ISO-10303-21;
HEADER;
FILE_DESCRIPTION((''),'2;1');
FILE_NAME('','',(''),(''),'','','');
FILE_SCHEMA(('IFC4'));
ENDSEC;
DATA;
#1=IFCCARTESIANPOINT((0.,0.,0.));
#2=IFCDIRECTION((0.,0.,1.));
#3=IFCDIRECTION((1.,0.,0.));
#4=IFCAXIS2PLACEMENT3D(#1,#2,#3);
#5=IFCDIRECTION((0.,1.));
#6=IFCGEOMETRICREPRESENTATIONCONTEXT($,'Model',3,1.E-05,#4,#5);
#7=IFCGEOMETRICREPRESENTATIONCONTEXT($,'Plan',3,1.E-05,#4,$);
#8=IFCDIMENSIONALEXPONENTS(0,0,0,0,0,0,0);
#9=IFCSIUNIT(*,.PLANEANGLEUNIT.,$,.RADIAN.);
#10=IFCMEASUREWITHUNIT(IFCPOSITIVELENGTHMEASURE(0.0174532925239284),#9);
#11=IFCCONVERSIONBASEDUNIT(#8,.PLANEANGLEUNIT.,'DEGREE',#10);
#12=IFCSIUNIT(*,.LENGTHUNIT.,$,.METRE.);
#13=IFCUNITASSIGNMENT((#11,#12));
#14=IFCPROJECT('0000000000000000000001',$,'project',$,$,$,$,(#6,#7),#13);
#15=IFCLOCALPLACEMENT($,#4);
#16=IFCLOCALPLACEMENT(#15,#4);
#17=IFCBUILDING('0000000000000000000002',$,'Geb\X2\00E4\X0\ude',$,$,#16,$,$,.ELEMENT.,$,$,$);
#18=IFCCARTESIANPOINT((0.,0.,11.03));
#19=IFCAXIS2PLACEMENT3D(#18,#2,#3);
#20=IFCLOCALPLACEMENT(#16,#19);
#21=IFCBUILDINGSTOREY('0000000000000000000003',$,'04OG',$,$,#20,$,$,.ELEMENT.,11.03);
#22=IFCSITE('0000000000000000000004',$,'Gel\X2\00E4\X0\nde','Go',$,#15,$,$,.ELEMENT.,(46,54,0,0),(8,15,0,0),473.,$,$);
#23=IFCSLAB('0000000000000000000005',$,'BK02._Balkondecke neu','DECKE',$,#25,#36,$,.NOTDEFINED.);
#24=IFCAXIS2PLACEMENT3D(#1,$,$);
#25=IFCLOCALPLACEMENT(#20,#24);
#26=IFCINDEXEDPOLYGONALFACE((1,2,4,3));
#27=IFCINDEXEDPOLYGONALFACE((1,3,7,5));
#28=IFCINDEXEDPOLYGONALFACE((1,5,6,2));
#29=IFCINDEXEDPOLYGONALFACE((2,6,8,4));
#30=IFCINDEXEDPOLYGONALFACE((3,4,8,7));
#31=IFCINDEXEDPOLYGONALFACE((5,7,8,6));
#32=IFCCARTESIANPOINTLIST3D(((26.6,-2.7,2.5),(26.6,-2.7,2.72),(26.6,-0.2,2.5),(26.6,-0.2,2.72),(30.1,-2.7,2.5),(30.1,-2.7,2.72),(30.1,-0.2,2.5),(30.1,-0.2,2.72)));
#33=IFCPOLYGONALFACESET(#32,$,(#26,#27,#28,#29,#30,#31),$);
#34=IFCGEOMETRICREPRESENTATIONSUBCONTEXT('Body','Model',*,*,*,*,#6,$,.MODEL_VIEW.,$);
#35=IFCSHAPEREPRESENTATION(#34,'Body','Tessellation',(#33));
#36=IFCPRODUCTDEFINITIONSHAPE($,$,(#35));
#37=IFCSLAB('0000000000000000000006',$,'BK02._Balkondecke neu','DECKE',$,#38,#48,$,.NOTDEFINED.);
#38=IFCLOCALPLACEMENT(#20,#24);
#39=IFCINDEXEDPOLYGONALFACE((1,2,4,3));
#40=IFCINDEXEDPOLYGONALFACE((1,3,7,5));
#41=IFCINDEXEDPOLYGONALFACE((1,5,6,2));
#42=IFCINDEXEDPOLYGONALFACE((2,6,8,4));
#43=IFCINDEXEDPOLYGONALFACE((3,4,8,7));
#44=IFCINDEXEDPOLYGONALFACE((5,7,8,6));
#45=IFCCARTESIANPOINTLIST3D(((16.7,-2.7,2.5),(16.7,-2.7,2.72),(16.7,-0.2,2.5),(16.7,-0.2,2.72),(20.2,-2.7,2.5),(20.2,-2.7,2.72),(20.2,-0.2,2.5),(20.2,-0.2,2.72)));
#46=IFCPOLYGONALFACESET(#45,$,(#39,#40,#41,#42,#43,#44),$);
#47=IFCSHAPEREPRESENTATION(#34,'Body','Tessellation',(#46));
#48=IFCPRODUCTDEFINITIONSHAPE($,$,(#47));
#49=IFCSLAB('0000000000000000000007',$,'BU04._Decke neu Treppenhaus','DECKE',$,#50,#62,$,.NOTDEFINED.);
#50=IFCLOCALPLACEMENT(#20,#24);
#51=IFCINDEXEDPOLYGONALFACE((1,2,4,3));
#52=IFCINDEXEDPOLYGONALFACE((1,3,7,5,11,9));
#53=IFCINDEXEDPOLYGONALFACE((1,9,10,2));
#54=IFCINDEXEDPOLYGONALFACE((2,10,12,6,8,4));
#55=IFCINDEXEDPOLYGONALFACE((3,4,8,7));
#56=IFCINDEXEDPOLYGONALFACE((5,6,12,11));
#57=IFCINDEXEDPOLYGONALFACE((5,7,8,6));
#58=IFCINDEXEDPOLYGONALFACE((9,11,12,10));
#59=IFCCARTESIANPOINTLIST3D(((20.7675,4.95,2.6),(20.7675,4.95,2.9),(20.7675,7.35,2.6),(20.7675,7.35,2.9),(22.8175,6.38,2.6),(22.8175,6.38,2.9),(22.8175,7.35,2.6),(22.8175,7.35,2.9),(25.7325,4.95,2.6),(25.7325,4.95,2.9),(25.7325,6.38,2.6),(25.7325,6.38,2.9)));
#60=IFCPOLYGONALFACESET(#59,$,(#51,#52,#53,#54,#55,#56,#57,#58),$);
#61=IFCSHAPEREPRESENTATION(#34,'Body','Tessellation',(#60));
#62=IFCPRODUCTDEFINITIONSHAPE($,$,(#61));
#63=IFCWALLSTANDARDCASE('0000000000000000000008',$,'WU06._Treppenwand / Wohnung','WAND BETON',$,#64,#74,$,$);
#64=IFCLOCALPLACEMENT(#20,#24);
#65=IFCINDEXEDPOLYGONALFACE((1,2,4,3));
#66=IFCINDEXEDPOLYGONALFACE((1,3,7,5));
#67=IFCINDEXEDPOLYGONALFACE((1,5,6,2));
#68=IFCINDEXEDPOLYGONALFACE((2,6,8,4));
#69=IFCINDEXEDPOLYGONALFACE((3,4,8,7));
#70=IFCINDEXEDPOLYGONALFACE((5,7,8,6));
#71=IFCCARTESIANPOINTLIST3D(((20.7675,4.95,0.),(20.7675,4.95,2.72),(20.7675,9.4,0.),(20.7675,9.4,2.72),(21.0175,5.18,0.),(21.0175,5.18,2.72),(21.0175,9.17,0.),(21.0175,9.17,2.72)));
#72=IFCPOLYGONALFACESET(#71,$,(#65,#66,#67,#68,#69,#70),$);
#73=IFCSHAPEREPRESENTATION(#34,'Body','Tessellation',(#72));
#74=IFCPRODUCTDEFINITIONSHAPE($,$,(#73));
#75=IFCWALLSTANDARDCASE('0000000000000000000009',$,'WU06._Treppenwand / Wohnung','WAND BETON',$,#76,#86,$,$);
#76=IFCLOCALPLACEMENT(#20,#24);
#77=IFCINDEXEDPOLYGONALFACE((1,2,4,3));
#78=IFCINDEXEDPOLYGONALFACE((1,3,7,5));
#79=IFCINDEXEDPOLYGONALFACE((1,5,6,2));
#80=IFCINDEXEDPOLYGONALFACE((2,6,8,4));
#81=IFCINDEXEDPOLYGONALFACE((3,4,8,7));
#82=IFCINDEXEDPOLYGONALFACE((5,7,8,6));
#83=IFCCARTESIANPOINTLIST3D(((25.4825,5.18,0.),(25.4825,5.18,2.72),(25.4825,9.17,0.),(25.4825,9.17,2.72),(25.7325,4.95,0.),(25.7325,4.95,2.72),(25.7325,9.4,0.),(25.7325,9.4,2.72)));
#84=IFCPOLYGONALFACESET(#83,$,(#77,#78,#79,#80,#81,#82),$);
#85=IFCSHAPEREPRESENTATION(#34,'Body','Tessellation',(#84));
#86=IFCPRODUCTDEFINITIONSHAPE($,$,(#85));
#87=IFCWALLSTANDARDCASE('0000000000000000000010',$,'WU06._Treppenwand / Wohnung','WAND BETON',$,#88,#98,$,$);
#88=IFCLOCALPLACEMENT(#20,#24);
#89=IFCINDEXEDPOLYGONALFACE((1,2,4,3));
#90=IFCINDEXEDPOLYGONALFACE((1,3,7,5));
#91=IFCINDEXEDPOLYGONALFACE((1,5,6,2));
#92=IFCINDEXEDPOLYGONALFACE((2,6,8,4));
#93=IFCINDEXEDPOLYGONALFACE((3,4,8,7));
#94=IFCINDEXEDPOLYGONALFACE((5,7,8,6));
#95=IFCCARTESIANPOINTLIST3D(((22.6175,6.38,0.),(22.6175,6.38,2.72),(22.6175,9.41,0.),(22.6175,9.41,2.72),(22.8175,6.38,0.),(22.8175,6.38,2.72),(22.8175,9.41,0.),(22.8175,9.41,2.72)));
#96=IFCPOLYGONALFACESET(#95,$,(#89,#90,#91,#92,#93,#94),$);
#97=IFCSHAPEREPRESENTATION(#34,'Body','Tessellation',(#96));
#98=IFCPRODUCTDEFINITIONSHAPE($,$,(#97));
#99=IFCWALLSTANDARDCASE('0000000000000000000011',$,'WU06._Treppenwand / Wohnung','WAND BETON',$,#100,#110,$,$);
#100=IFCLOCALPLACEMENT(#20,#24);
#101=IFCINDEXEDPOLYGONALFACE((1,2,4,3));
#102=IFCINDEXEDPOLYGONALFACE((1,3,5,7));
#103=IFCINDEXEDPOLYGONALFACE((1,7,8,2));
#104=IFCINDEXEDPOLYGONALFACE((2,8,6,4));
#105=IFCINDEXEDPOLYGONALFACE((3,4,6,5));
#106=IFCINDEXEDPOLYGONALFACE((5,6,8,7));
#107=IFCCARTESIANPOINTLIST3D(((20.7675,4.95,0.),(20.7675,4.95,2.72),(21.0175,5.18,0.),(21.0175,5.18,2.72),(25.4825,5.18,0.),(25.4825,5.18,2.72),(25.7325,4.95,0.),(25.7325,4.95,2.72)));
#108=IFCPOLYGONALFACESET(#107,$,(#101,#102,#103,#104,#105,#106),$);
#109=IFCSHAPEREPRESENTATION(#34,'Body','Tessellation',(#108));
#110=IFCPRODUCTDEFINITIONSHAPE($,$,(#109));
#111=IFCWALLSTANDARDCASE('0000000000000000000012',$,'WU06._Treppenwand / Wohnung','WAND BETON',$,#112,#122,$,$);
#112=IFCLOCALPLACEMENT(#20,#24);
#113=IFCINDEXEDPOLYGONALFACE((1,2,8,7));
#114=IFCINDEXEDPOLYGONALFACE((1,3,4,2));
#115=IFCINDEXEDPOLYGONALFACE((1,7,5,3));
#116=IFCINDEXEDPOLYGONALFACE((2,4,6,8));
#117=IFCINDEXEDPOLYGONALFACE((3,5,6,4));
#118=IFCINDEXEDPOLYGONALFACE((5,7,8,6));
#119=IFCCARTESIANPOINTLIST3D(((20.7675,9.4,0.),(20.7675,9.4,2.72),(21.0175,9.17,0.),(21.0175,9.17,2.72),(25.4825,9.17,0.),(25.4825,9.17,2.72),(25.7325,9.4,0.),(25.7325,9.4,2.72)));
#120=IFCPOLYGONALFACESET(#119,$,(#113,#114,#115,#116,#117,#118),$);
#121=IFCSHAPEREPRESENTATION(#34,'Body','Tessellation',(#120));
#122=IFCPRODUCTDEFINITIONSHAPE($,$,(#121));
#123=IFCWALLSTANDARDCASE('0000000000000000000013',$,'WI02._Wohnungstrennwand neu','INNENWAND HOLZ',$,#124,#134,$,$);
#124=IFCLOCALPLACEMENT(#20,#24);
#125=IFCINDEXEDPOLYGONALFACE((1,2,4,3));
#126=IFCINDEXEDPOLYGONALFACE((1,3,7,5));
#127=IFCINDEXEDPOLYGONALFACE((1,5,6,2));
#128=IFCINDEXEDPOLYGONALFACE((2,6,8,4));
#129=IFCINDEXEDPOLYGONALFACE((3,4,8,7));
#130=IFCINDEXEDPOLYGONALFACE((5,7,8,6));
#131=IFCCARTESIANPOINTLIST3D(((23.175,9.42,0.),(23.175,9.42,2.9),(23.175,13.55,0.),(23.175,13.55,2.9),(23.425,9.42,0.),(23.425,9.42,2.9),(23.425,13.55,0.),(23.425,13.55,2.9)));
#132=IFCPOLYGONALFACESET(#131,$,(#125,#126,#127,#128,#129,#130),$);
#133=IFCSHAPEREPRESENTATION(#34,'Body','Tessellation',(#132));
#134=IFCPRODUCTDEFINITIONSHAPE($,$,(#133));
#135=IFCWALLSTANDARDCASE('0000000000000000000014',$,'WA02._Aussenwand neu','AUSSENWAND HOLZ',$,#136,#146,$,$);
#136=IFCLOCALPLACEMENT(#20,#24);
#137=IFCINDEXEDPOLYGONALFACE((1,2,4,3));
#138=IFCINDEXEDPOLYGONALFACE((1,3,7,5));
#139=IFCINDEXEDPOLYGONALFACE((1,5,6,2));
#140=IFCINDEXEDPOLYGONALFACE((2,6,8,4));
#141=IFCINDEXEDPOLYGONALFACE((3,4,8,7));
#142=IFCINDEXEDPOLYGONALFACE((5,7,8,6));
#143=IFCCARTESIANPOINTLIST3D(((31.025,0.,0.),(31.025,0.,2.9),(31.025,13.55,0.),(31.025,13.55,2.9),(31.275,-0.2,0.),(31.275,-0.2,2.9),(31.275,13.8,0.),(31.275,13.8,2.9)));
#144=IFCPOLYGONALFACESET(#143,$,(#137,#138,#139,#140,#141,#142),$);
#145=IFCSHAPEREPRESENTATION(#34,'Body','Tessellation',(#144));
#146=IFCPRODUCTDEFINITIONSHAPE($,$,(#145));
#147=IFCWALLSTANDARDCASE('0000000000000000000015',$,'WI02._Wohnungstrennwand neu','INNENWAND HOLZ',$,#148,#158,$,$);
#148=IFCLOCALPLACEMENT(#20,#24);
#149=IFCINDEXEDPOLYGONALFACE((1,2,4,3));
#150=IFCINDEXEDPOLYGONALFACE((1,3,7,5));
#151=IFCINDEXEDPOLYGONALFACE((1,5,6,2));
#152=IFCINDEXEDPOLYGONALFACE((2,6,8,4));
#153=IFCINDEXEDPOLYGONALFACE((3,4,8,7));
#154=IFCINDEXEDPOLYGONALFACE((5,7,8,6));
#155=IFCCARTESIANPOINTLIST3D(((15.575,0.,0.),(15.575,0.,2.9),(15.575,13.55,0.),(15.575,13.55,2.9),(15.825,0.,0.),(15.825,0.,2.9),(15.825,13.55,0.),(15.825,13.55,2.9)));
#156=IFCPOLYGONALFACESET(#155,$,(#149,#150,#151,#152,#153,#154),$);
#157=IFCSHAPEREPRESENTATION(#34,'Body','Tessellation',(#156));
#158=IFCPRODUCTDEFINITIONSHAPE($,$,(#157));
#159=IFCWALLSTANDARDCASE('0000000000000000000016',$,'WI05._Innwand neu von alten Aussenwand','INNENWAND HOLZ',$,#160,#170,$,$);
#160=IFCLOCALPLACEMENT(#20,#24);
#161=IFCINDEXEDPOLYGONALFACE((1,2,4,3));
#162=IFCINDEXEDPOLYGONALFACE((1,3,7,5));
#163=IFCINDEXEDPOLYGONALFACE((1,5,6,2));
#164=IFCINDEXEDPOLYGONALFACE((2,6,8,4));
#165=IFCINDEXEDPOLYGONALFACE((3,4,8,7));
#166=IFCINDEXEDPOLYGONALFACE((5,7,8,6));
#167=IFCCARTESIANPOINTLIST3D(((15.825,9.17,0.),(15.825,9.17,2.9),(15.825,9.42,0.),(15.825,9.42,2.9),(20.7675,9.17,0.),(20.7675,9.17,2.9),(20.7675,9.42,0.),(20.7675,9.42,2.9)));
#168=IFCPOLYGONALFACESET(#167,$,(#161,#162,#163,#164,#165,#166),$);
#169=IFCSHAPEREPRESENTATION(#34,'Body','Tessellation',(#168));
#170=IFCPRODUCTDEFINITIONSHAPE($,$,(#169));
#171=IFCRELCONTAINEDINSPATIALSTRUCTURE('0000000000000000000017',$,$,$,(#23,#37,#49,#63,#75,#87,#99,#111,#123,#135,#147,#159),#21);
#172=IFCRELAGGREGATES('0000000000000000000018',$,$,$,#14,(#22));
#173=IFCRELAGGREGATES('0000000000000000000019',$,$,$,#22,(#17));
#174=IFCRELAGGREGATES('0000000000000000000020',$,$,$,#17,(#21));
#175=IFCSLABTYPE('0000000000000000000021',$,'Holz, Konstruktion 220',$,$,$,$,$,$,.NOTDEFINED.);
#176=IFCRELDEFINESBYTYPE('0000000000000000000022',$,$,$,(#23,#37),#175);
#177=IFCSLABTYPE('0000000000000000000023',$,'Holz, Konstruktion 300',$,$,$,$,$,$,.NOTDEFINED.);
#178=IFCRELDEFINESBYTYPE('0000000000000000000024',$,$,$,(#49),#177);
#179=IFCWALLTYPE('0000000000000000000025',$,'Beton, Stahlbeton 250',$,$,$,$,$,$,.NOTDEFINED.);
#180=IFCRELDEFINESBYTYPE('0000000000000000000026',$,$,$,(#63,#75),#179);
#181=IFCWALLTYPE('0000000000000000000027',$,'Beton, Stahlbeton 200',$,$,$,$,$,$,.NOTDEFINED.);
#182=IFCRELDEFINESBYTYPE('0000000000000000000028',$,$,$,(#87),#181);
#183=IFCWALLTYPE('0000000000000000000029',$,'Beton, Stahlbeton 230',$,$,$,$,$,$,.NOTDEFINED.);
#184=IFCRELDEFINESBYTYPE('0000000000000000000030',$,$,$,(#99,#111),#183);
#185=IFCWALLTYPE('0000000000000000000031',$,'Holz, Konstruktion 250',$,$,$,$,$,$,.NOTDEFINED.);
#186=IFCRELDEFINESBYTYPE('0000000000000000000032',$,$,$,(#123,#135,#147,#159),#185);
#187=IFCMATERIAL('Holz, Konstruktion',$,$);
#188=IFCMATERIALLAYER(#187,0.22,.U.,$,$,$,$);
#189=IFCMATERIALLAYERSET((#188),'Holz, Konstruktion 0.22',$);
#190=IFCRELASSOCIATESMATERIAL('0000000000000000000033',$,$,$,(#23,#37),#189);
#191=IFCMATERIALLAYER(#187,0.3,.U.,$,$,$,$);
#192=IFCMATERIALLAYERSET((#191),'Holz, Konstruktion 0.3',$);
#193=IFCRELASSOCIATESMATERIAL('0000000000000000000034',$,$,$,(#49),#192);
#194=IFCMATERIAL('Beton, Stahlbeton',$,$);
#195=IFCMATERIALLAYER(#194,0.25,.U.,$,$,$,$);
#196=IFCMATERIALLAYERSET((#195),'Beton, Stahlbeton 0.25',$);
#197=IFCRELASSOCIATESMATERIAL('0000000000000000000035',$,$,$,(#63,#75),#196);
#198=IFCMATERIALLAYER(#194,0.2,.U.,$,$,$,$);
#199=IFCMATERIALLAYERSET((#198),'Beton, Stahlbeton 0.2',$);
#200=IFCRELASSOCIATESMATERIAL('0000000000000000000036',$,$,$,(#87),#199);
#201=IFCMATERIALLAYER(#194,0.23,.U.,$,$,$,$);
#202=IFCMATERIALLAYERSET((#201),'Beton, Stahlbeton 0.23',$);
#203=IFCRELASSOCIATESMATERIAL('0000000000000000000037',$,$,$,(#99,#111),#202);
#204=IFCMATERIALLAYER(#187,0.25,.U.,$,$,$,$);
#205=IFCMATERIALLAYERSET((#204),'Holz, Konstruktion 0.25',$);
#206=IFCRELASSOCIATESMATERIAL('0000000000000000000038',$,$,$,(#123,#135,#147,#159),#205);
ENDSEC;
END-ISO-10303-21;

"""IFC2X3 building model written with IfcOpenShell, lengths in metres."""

from ifc_helpers import new_model, entity, si_unit, converted_unit, direction, frame, origin_with_axes, place, context, subcontext, project, spatial, polyline, outline, extrude, material, layer, layer_set, layer_usage, type_object, element, save


model = new_model("IFC2X3")

# Units and contexts
model_context = context("Model", 3, precision=1e-05, world=origin_with_axes(), true_north=direction((0.0, 1.0)))
plan_context = context("Plan", 3, precision=1e-05, world=origin_with_axes())
body_context = subcontext(model_context, "Body", "Model", "MODEL_VIEW")
ifc_project = project(units=[converted_unit("PLANEANGLEUNIT", "DEGREE", entity("IfcPositiveLengthMeasure", 0.0174532925239284), si_unit("PLANEANGLEUNIT", "RADIAN"), dimensions=[0, 0, 0, 0, 0, 0, 0]), si_unit("LENGTHUNIT", "METRE")], contexts=[model_context, plan_context])

# Site, building, storey
site_placement = place(None, origin_with_axes())
site = spatial("IfcSite", under=ifc_project, at=site_placement, Name="Gelände", Description="Go", CompositionType="ELEMENT", RefLatitude=(46, 54, 0, 0), RefLongitude=(8, 15, 0, 0), RefElevation=473.0)
building_placement = place(site_placement, origin_with_axes())
building = spatial("IfcBuilding", under=site, at=building_placement, Name="Gebäude", CompositionType="ELEMENT")
storey_placement = place(building_placement, frame((0.0, 0.0, 11.03), z_axis=(0.0, 0.0, 1.0), x_axis=(1.0, 0.0, 0.0)))
storey = spatial("IfcBuildingStorey", under=building, at=storey_placement, Name="04OG", CompositionType="ELEMENT", Elevation=11.03)

# Slabs
ifc_material_1 = material(Name="Holz, Konstruktion")
ifc_layer_1 = layer(ifc_material_1, 0.22, ventilated="UNKNOWN")
ifc_layer_set_1 = layer_set([ifc_layer_1], Name="Holz, Konstruktion 0.22")
ifc_layer_usage_1 = layer_usage(ifc_layer_set_1, "AXIS3", "NEGATIVE", 0.22)
slab_type_1 = type_object("IfcSlabType", Name="Holz, Konstruktion 220", PredefinedType="NOTDEFINED")
slab_1_placement = place(storey_placement, frame((26.6, -2.7, 2.72), z_axis=(0.0, 0.0, 1.0), x_axis=(1.0, 0.0, 0.0)))
element("IfcSlab", 1, at=slab_1_placement, inside=storey, type_object=slab_type_1, material=ifc_layer_usage_1, Name="BK02._Balkondecke neu", Description="DECKE", PredefinedType="NOTDEFINED", context=body_context, shape_type="SweptSolid", body=[
    extrude(outline(polyline([(0.0, 0.0), (3.5, 0.0), (3.5, 2.5), (0.0, 2.5), (0.0, 0.0)])), frame((0.0, 0.0, -0.22), z_axis=(0.0, 0.0, 1.0), x_axis=(1.0, 0.0, 0.0)), (0.0, 0.0, 1.0), 0.22),
])
ifc_layer_usage_2 = layer_usage(ifc_layer_set_1, "AXIS3", "NEGATIVE", 0.22)
slab_2_placement = place(storey_placement, frame((16.7, -2.7, 2.72), z_axis=(0.0, 0.0, 1.0), x_axis=(1.0, 0.0, 0.0)))
element("IfcSlab", 2, at=slab_2_placement, inside=storey, type_object=slab_type_1, material=ifc_layer_usage_2, Name="BK02._Balkondecke neu", Description="DECKE", PredefinedType="NOTDEFINED", context=body_context, shape_type="SweptSolid", body=[
    extrude(outline(polyline([(0.0, 0.0), (3.5, 0.0), (3.5, 2.5), (0.0, 2.5), (0.0, 0.0)])), frame((0.0, 0.0, -0.22), z_axis=(0.0, 0.0, 1.0), x_axis=(1.0, 0.0, 0.0)), (0.0, 0.0, 1.0), 0.22),
])
ifc_layer_2 = layer(ifc_material_1, 0.3, ventilated="UNKNOWN")
ifc_layer_set_2 = layer_set([ifc_layer_2], Name="Holz, Konstruktion 0.3")
ifc_layer_usage_3 = layer_usage(ifc_layer_set_2, "AXIS3", "NEGATIVE", 0.3)
slab_type_2 = type_object("IfcSlabType", Name="Holz, Konstruktion 300", PredefinedType="NOTDEFINED")
slab_3_placement = place(storey_placement, frame((20.7675, 7.35, 2.9), z_axis=(0.0, 0.0, 1.0), x_axis=(1.0, 0.0, 0.0)))
element("IfcSlab", 3, at=slab_3_placement, inside=storey, type_object=slab_type_2, material=ifc_layer_usage_3, Name="BU04._Decke neu Treppenhaus", Description="DECKE", PredefinedType="NOTDEFINED", context=body_context, shape_type="SweptSolid", body=[
    extrude(outline(polyline([(0.0, 0.0), (0.0, -2.4), (4.965, -2.4), (4.965, -0.97), (2.05, -0.97), (2.05, 0.0), (0.0, 0.0)])), frame((0.0, 0.0, -0.3), z_axis=(0.0, 0.0, 1.0), x_axis=(1.0, 0.0, 0.0)), (0.0, 0.0, 1.0), 0.3),
])

# Walls
ifc_material_2 = material(Name="Beton, Stahlbeton")
ifc_layer_3 = layer(ifc_material_2, 0.25, ventilated="UNKNOWN")
ifc_layer_set_3 = layer_set([ifc_layer_3], Name="Beton, Stahlbeton 0.25")
ifc_layer_usage_4 = layer_usage(ifc_layer_set_3, "AXIS2", "NEGATIVE", 0.25)
wall_type_1 = type_object("IfcWallType", Name="Beton, Stahlbeton 250", PredefinedType="NOTDEFINED")
wall_1_placement = place(storey_placement, frame((21.0175, 5.18, 0.0), z_axis=(0.0, 0.0, 1.0), x_axis=(0.0, 1.0, 0.0)))
element("IfcWallStandardCase", 4, at=wall_1_placement, inside=storey, type_object=wall_type_1, material=ifc_layer_usage_4, Name="WU06._Treppenwand / Wohnung", Description="WAND BETON", context=body_context, shape_type="SweptSolid", body=[
    extrude(outline(polyline([(0.0, 0.0), (3.99, 0.0), (4.22, 0.25), (-0.23, 0.25), (0.0, 0.0)])), origin_with_axes(), (0.0, 0.0, 1.0), 2.72),
])
ifc_layer_usage_5 = layer_usage(ifc_layer_set_3, "AXIS2", "NEGATIVE", 0.25)
wall_2_placement = place(storey_placement, frame((25.4825, 9.17, 0.0), z_axis=(0.0, 0.0, 1.0), x_axis=(0.0, -1.0, 0.0)))
element("IfcWallStandardCase", 5, at=wall_2_placement, inside=storey, type_object=wall_type_1, material=ifc_layer_usage_5, Name="WU06._Treppenwand / Wohnung", Description="WAND BETON", context=body_context, shape_type="SweptSolid", body=[
    extrude(outline(polyline([(0.0, 0.0), (3.99, 0.0), (4.22, 0.25), (-0.23, 0.25), (0.0, 0.0)])), origin_with_axes(), (0.0, 0.0, 1.0), 2.72),
])
ifc_layer_4 = layer(ifc_material_2, 0.2, ventilated="UNKNOWN")
ifc_layer_set_4 = layer_set([ifc_layer_4], Name="Beton, Stahlbeton 0.2")
ifc_layer_usage_6 = layer_usage(ifc_layer_set_4, "AXIS2", "POSITIVE", -0.2)
wall_type_2 = type_object("IfcWallType", Name="Beton, Stahlbeton 200", PredefinedType="NOTDEFINED")
wall_3_placement = place(storey_placement, frame((22.6175, 6.38, 0.0), z_axis=(0.0, 0.0, 1.0), x_axis=(0.0, 1.0, 0.0)))
element("IfcWallStandardCase", 6, at=wall_3_placement, inside=storey, type_object=wall_type_2, material=ifc_layer_usage_6, Name="WU06._Treppenwand / Wohnung", Description="WAND BETON", context=body_context, shape_type="SweptSolid", body=[
    extrude(outline(polyline([(0.0, -0.2), (3.03, -0.2), (3.03, 0.0), (0.0, 0.0), (0.0, -0.2)])), origin_with_axes(), (0.0, 0.0, 1.0), 2.72),
])
ifc_layer_5 = layer(ifc_material_2, 0.23, ventilated="UNKNOWN")
ifc_layer_set_5 = layer_set([ifc_layer_5], Name="Beton, Stahlbeton 0.23")
ifc_layer_usage_7 = layer_usage(ifc_layer_set_5, "AXIS2", "NEGATIVE", 0.23)
wall_type_3 = type_object("IfcWallType", Name="Beton, Stahlbeton 230", PredefinedType="NOTDEFINED")
wall_4_placement = place(storey_placement, frame((25.4825, 5.18, 0.0), z_axis=(0.0, 0.0, 1.0), x_axis=(-1.0, 0.0, 0.0)))
element("IfcWallStandardCase", 7, at=wall_4_placement, inside=storey, type_object=wall_type_3, material=ifc_layer_usage_7, Name="WU06._Treppenwand / Wohnung", Description="WAND BETON", context=body_context, shape_type="SweptSolid", body=[
    extrude(outline(polyline([(0.0, 0.0), (4.465, 0.0), (4.715, 0.23), (-0.25, 0.23), (0.0, 0.0)])), origin_with_axes(), (0.0, 0.0, 1.0), 2.72),
])
ifc_layer_usage_8 = layer_usage(ifc_layer_set_5, "AXIS2", "NEGATIVE", 0.23)
wall_5_placement = place(storey_placement, frame((21.0175, 9.17, 0.0), z_axis=(0.0, 0.0, 1.0), x_axis=(1.0, 0.0, 0.0)))
element("IfcWallStandardCase", 8, at=wall_5_placement, inside=storey, type_object=wall_type_3, material=ifc_layer_usage_8, Name="WU06._Treppenwand / Wohnung", Description="WAND BETON", context=body_context, shape_type="SweptSolid", body=[
    extrude(outline(polyline([(0.0, 0.0), (4.465, 0.0), (4.715, 0.23), (-0.25, 0.23), (0.0, 0.0)])), origin_with_axes(), (0.0, 0.0, 1.0), 2.72),
])
ifc_layer_6 = layer(ifc_material_1, 0.25, ventilated="UNKNOWN")
ifc_layer_set_6 = layer_set([ifc_layer_6], Name="Holz, Konstruktion 0.25")
ifc_layer_usage_9 = layer_usage(ifc_layer_set_6, "AXIS2", "NEGATIVE", 0.0)
wall_type_4 = type_object("IfcWallType", Name="Holz, Konstruktion 250", PredefinedType="NOTDEFINED")
wall_6_placement = place(storey_placement, frame((23.425, 13.55, 0.0), z_axis=(0.0, 0.0, 1.0), x_axis=(0.0, -1.0, 0.0)))
element("IfcWallStandardCase", 9, at=wall_6_placement, inside=storey, type_object=wall_type_4, material=ifc_layer_usage_9, Name="WI02._Wohnungstrennwand neu", Description="INNENWAND HOLZ", context=body_context, shape_type="SweptSolid", body=[
    extrude(outline(polyline([(0.0, -0.25), (4.13, -0.25), (4.13, 0.0), (0.0, 0.0), (0.0, -0.25)])), origin_with_axes(), (0.0, 0.0, 1.0), 2.9),
])
ifc_layer_usage_10 = layer_usage(ifc_layer_set_6, "AXIS2", "POSITIVE", 0.0)
wall_7_placement = place(storey_placement, frame((31.275, -0.2, 0.0), z_axis=(0.0, 0.0, 1.0), x_axis=(0.0, 1.0, 0.0)))
element("IfcWallStandardCase", 10, at=wall_7_placement, inside=storey, type_object=wall_type_4, material=ifc_layer_usage_10, Name="WA02._Aussenwand neu", Description="AUSSENWAND HOLZ", context=body_context, shape_type="SweptSolid", body=[
    extrude(outline(polyline([(0.0, 0.0), (14.0, 0.0), (13.75, 0.25), (0.2, 0.25), (0.0, 0.0)])), origin_with_axes(), (0.0, 0.0, 1.0), 2.9),
])
ifc_layer_usage_11 = layer_usage(ifc_layer_set_6, "AXIS2", "NEGATIVE", 0.0)
wall_8_placement = place(storey_placement, frame((15.825, 13.55, 0.0), z_axis=(0.0, 0.0, 1.0), x_axis=(0.0, -1.0, 0.0)))
element("IfcWallStandardCase", 11, at=wall_8_placement, inside=storey, type_object=wall_type_4, material=ifc_layer_usage_11, Name="WI02._Wohnungstrennwand neu", Description="INNENWAND HOLZ", context=body_context, shape_type="SweptSolid", body=[
    extrude(outline(polyline([(0.0, -0.25), (13.55, -0.25), (13.55, 0.0), (0.0, 0.0), (0.0, -0.25)])), origin_with_axes(), (0.0, 0.0, 1.0), 2.9),
])
ifc_layer_usage_12 = layer_usage(ifc_layer_set_6, "AXIS2", "NEGATIVE", 0.0)
wall_9_placement = place(storey_placement, frame((15.825, 9.42, 0.0), z_axis=(0.0, 0.0, 1.0), x_axis=(1.0, 0.0, 0.0)))
element("IfcWallStandardCase", 12, at=wall_9_placement, inside=storey, type_object=wall_type_4, material=ifc_layer_usage_12, Name="WI05._Innwand neu von alten Aussenwand", Description="INNENWAND HOLZ", context=body_context, shape_type="SweptSolid", body=[
    extrude(outline(polyline([(0.0, -0.25), (4.9425, -0.25), (4.9425, 0.0), (0.0, 0.0), (0.0, -0.25)])), origin_with_axes(), (0.0, 0.0, 1.0), 2.9),
])

save(model, "model.ifc")
